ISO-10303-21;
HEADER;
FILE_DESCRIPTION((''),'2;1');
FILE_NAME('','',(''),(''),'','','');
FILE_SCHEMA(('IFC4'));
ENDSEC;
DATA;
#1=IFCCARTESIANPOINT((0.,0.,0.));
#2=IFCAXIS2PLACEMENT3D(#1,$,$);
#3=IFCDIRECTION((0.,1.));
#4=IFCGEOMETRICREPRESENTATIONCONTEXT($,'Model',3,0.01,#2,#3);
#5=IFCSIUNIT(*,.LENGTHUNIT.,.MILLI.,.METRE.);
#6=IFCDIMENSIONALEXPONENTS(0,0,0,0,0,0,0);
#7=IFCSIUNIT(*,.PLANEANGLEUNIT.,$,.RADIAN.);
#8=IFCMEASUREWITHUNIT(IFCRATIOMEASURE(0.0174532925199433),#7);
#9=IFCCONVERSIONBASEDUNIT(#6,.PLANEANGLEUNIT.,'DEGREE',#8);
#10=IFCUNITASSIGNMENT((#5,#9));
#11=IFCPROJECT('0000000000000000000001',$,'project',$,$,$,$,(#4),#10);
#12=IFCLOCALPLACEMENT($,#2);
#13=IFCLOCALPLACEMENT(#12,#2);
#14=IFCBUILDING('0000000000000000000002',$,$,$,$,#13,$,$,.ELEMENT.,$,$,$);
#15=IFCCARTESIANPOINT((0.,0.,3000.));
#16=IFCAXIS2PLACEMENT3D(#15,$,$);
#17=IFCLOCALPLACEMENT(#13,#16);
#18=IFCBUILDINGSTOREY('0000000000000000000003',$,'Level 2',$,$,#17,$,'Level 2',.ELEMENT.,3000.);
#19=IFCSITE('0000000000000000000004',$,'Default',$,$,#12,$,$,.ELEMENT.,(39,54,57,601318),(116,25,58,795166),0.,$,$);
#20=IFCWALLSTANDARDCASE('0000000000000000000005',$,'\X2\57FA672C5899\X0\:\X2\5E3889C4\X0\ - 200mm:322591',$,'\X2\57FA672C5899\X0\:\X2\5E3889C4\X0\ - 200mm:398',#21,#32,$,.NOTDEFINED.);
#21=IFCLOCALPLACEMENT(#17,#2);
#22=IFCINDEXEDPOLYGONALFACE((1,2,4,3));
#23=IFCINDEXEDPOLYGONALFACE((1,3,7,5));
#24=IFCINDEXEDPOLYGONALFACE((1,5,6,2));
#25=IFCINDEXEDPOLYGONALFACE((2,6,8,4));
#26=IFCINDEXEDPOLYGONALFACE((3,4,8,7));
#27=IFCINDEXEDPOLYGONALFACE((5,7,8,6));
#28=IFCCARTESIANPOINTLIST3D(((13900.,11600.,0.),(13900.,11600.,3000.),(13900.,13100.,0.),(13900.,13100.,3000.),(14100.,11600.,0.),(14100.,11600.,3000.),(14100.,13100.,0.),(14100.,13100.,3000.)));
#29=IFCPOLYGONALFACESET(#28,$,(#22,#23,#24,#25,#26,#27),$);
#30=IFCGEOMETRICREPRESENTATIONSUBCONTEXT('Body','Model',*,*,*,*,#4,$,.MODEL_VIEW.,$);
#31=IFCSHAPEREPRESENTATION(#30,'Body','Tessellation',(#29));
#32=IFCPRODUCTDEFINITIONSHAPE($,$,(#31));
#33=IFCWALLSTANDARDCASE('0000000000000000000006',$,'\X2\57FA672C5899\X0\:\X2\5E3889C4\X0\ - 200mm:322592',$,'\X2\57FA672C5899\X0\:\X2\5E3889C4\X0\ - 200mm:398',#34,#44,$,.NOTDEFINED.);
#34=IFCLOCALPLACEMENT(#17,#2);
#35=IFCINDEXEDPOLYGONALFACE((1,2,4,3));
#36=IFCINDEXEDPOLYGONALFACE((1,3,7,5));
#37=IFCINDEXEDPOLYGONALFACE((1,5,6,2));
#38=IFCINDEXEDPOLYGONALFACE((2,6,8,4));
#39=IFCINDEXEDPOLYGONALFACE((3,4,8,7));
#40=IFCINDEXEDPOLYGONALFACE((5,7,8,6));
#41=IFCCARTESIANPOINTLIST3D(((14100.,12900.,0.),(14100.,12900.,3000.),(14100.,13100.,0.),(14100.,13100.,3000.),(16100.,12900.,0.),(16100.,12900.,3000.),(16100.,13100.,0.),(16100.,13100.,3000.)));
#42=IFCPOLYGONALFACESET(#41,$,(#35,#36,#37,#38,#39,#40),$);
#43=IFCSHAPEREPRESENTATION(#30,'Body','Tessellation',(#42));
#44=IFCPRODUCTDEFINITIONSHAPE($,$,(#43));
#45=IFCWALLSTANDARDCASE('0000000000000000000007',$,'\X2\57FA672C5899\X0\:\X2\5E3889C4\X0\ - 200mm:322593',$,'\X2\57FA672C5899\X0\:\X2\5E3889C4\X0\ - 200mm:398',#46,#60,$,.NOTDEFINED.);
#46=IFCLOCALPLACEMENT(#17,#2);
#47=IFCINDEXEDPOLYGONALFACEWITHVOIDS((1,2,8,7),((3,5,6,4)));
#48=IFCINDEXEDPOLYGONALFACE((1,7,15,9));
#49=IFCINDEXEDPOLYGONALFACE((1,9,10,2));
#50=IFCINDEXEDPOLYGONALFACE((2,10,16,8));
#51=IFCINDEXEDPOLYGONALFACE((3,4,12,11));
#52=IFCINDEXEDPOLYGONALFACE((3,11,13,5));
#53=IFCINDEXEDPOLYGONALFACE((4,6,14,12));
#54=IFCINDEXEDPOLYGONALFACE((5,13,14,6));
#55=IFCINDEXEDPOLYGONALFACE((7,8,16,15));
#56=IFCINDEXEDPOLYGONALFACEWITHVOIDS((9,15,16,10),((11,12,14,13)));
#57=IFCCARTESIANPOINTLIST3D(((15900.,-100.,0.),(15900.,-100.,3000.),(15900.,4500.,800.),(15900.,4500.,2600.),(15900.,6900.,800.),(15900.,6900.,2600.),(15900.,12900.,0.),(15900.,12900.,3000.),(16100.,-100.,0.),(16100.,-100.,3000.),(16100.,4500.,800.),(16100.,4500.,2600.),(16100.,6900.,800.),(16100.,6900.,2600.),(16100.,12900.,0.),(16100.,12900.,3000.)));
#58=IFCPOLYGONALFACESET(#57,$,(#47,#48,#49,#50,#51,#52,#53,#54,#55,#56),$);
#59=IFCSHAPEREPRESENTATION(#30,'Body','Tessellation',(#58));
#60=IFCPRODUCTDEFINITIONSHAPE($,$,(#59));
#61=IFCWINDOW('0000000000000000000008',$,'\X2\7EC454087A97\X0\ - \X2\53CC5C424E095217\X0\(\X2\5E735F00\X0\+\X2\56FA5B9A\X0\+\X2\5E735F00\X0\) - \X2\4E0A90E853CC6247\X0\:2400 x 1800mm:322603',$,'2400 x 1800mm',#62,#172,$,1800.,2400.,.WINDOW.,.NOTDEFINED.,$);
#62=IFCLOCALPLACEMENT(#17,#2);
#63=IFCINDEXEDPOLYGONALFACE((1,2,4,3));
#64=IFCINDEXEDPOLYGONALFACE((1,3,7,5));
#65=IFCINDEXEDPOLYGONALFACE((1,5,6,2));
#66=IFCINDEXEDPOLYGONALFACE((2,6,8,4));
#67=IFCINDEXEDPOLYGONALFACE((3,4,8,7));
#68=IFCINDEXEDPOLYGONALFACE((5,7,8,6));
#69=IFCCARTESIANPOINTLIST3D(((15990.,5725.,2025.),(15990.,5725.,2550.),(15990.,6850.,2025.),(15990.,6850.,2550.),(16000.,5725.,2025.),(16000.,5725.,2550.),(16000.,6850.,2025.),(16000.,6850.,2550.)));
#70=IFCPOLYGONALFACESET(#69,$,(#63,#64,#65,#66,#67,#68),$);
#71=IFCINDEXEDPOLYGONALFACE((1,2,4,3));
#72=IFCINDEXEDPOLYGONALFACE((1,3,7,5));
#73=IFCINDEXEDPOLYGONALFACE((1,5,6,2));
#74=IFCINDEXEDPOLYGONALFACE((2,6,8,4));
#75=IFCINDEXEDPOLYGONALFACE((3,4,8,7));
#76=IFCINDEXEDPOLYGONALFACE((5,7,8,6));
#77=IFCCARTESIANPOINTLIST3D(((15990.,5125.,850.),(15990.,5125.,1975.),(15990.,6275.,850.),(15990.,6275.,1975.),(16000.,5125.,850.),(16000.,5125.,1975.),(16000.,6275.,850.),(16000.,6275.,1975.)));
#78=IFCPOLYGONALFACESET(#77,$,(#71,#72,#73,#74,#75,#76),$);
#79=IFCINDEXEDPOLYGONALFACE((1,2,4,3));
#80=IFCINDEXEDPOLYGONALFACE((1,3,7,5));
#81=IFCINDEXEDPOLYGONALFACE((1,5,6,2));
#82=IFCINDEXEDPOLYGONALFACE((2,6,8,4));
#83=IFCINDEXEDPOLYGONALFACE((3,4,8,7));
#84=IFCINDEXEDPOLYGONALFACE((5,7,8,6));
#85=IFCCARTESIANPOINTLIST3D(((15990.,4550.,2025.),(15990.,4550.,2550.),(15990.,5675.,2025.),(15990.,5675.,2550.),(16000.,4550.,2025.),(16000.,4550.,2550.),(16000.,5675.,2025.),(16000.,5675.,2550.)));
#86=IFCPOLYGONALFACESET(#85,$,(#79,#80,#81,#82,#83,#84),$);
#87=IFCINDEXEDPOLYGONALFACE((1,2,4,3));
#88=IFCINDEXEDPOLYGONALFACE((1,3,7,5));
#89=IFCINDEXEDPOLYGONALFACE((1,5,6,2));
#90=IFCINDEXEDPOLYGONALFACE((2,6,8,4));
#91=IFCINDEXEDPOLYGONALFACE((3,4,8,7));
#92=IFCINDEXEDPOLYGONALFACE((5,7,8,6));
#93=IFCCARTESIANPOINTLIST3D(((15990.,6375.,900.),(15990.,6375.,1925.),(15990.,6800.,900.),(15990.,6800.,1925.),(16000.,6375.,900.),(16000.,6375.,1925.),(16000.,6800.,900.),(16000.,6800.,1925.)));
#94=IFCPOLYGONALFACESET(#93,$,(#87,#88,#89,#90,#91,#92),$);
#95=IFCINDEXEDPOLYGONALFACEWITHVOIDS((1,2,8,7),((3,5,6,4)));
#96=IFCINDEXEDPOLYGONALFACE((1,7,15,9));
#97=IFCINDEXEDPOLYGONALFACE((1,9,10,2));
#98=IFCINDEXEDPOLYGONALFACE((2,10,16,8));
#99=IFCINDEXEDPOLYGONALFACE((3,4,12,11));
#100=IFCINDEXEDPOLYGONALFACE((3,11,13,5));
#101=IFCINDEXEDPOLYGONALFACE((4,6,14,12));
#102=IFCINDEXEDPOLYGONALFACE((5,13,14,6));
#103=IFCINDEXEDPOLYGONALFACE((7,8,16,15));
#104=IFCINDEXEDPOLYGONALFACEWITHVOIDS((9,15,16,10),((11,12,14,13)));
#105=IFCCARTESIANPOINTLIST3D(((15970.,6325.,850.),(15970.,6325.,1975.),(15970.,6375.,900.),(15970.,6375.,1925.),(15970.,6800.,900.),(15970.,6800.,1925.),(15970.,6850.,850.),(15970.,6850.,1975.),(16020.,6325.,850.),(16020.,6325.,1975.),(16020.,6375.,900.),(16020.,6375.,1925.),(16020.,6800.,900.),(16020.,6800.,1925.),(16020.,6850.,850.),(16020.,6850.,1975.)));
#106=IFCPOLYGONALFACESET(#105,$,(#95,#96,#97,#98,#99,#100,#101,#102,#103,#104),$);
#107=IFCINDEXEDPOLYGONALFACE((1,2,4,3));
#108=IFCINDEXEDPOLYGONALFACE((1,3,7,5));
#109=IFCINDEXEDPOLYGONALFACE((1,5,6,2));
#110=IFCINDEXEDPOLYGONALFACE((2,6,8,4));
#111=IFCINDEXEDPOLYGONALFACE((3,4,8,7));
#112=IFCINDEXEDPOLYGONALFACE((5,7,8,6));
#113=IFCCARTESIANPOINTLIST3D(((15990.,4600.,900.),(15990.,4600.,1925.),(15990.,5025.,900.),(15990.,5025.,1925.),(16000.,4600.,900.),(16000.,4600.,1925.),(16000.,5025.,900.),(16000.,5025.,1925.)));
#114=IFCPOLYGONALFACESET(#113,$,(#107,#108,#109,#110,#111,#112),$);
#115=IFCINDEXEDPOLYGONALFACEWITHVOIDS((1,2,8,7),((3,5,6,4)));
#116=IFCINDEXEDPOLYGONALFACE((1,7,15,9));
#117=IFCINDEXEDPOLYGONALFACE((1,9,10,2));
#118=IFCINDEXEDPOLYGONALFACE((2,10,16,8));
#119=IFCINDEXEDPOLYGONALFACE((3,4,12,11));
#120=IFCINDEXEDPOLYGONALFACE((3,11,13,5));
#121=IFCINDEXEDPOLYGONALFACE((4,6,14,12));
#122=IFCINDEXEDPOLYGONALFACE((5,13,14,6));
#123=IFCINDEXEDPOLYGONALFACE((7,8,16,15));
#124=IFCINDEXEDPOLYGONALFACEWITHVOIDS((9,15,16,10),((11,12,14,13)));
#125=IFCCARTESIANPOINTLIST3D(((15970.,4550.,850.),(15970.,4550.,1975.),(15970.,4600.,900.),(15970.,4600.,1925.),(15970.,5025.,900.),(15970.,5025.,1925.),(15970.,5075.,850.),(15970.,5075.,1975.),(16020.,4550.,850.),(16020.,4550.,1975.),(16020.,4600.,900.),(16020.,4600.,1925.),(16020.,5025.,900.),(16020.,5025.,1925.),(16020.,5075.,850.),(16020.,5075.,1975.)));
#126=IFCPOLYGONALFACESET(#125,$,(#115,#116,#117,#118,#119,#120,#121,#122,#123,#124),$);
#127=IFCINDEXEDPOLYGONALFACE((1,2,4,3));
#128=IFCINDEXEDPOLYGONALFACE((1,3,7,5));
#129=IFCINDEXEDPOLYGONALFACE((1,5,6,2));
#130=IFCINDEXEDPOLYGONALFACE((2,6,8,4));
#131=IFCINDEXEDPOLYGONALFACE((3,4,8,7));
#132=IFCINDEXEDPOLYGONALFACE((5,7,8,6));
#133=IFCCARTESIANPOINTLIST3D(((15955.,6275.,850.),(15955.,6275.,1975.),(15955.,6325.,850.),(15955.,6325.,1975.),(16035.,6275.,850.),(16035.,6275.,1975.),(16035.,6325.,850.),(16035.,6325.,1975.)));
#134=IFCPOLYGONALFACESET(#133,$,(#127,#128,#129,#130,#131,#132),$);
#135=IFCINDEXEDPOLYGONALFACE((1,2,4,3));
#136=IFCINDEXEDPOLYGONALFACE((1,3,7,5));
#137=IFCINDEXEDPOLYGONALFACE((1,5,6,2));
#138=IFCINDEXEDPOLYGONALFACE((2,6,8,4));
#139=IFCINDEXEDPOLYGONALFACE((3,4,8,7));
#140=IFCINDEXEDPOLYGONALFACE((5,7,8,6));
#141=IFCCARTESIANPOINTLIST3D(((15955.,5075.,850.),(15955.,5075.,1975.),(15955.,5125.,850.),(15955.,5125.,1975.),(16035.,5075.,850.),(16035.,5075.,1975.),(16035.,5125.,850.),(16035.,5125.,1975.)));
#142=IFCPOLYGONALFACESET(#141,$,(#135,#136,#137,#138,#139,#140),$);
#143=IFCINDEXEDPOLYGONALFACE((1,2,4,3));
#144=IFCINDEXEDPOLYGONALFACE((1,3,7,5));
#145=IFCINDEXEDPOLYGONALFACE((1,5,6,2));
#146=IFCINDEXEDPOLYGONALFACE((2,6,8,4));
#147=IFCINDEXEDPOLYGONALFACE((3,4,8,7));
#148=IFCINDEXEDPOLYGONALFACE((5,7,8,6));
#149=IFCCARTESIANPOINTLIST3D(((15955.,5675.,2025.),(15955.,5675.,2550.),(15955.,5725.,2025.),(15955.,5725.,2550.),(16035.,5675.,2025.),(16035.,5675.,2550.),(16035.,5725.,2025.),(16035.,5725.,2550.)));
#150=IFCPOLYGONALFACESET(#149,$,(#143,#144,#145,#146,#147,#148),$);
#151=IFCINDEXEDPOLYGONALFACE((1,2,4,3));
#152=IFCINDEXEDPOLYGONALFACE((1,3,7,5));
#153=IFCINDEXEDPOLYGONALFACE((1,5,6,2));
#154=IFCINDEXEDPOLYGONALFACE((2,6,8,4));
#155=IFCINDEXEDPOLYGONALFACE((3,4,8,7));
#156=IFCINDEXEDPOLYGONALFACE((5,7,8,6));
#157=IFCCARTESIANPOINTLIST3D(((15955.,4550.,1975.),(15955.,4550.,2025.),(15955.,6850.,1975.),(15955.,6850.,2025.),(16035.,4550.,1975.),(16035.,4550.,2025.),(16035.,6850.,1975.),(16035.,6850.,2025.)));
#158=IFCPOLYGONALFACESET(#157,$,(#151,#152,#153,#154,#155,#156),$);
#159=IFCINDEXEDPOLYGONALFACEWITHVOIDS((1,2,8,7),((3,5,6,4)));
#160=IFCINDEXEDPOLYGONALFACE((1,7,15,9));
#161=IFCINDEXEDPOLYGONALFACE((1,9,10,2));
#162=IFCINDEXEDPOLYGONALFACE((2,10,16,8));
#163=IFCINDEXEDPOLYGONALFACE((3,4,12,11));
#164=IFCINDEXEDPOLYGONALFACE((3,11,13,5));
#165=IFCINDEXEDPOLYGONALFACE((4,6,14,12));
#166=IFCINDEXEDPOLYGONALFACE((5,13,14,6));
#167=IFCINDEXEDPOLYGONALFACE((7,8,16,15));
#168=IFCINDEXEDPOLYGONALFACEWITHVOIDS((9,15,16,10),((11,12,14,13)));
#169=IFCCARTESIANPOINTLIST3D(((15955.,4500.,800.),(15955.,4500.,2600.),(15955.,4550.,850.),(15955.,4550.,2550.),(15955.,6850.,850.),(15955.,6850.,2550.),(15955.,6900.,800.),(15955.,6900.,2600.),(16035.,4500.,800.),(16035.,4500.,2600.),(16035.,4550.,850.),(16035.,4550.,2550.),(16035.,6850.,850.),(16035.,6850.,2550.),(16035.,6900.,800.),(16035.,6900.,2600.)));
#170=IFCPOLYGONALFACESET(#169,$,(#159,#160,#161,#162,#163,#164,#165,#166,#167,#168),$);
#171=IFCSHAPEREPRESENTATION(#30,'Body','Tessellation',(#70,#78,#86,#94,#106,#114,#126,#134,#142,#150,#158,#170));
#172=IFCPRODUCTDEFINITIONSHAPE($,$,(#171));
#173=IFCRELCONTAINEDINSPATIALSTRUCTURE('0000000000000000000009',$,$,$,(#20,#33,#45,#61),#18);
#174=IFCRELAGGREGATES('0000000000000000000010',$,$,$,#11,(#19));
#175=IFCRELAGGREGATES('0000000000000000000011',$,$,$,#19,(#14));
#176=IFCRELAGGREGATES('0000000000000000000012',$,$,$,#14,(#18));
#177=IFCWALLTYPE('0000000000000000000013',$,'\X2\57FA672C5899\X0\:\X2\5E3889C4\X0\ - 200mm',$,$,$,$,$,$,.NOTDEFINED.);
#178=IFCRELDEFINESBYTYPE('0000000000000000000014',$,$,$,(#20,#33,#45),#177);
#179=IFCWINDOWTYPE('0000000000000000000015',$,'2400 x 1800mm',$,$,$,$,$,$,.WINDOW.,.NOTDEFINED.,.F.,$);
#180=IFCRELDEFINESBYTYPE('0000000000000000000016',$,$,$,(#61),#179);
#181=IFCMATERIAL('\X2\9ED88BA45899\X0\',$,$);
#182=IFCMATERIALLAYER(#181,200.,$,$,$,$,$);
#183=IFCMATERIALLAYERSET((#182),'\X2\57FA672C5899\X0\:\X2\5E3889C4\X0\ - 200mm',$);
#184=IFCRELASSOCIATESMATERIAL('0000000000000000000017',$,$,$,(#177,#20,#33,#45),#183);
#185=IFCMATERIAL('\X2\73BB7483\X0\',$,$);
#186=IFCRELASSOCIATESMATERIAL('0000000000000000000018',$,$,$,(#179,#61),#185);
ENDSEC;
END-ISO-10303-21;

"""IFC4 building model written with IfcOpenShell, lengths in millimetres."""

from ifc_helpers import new_model, entity, si_unit, converted_unit, direction, frame, frame_2d, origin, origin_2d_with_axis, place, context, subcontext, project, spatial, polyline, rectangle, outline, extrude, source, transform, mapped, material, layer, layer_set, layer_usage, type_object, type_shapes, element, fill, save


model = new_model("IFC4")

# Units and contexts
model_context_1 = context("Model", 3, precision=0.01, world=origin(), true_north=direction((0.0, 1.0)))
body_context_1 = subcontext(model_context_1, "Body", "Model", "MODEL_VIEW")
ifc_project = project(units=[si_unit("LENGTHUNIT", "METRE", prefix="MILLI"), converted_unit("PLANEANGLEUNIT", "DEGREE", entity("IfcRatioMeasure", 0.0174532925199433), si_unit("PLANEANGLEUNIT", "RADIAN"), dimensions=[0, 0, 0, 0, 0, 0, 0])], contexts=[model_context_1])

# Site, building, storey
site_placement = place(None, origin())
site = spatial("IfcSite", under=ifc_project, at=site_placement, Name="Default", CompositionType="ELEMENT", RefLatitude=(39, 54, 57, 601318), RefLongitude=(116, 25, 58, 795166), RefElevation=0.0)
building_placement = place(site_placement, origin())
building = spatial("IfcBuilding", under=site, at=building_placement, CompositionType="ELEMENT")
storey_placement = place(building_placement, frame((0.0, 0.0, 3000.0)))
storey = spatial("IfcBuildingStorey", under=building, at=storey_placement, Name="Level 2", LongName="Level 2", CompositionType="ELEMENT", Elevation=3000.0)

# Shared definitions
ifc_material_1 = material(Name="默认墙")
ifc_layer = layer(ifc_material_1, 200.0)
ifc_layer_set = layer_set([ifc_layer], Name="基本墙:常规 - 200mm")
wall_type = type_object("IfcWallType", Name="基本墙:常规 - 200mm", PredefinedType="NOTDEFINED", material=ifc_layer_set)

# Walls
ifc_layer_usage_1 = layer_usage(ifc_layer_set, "AXIS2", "NEGATIVE", 100.0)
wall_1_placement = place(storey_placement, frame((14000.0, 11600.0, 0.0), z_axis=(0.0, 0.0, 1.0), x_axis=(0.0, 1.0, 0.0)))
element("IfcWallStandardCase", 1, at=wall_1_placement, inside=storey, type_object=wall_type, material=ifc_layer_usage_1, Name="基本墙:常规 - 200mm:322591", ObjectType="基本墙:常规 - 200mm:398", PredefinedType="NOTDEFINED", context=body_context_1, shape_type="SweptSolid", body=[
    extrude(rectangle(XDim=1500.0, YDim=200.0, at=frame_2d((750.0, 0.0), x_axis=(-1.0, 0.0))), origin(), (0.0, 0.0, 1.0), 3000.0),
])
ifc_layer_usage_2 = layer_usage(ifc_layer_set, "AXIS2", "NEGATIVE", 100.0)
wall_2_placement = place(storey_placement, frame((14100.0, 13000.0, 0.0)))
element("IfcWallStandardCase", 2, at=wall_2_placement, inside=storey, type_object=wall_type, material=ifc_layer_usage_2, Name="基本墙:常规 - 200mm:322592", ObjectType="基本墙:常规 - 200mm:398", PredefinedType="NOTDEFINED", context=body_context_1, shape_type="SweptSolid", body=[
    extrude(rectangle(XDim=2000.0, YDim=200.0, at=frame_2d((1000.0, 0.0), x_axis=(-1.0, 0.0))), origin(), (0.0, 0.0, 1.0), 3000.0),
])

# Wall, opening, window
ifc_layer_usage_3 = layer_usage(ifc_layer_set, "AXIS2", "NEGATIVE", 100.0)
wall_3_placement = place(storey_placement, frame((16000.0, 12900.0, 0.0), z_axis=(0.0, 0.0, 1.0), x_axis=(0.0, -1.0, 0.0)))
wall_3 = element("IfcWallStandardCase", 3, at=wall_3_placement, inside=storey, type_object=wall_type, material=ifc_layer_usage_3, Name="基本墙:常规 - 200mm:322593", ObjectType="基本墙:常规 - 200mm:398", PredefinedType="NOTDEFINED", context=body_context_1, shape_type="SweptSolid", body=[
    extrude(rectangle(XDim=13000.0, YDim=200.0, at=frame_2d((6500.0, 0.0), x_axis=(-1.0, 0.0))), origin(), (0.0, 0.0, 1.0), 3000.0),
])
opening_1_placement = place(wall_3_placement, frame((6000.0, -100.0, 800.0)))
opening_1 = element("IfcOpeningElement", 4, at=opening_1_placement, cuts=wall_3, ObjectType="Opening", PredefinedType="OPENING", context=body_context_1, shape_type="SweptSolid", body=[
    extrude(rectangle(XDim=1800.0, YDim=2400.0, at=frame_2d((900.0, 1200.0), x_axis=(1.0, 0.0))), frame((0.0, 0.0, 0.0), z_axis=(0.0, 1.0, 0.0), x_axis=(0.0, 0.0, 1.0)), (0.0, 0.0, 1.0), 200.0),
])
ifc_material_2 = material(Name="玻璃")
window_type_1 = type_object("IfcWindowType", Name="2400 x 1800mm", ParameterTakesPrecedence=False, PartitioningType="NOTDEFINED", PredefinedType="WINDOW", material=ifc_material_2)
shared_shape_1 = source(origin(), body_context_1, "Body", "SweptSolid", [
    extrude(rectangle(XDim=10.0, YDim=1125.0, at=origin_2d_with_axis()), frame((612.5, 95.0, 1225.0), z_axis=(0.0, 0.0, 1.0), x_axis=(0.0, 1.0, 0.0)), (0.0, 0.0, 1.0), 525.0),
    extrude(rectangle(XDim=10.0, YDim=1150.0, at=origin_2d_with_axis()), frame((1200.0, 95.0, 50.0), z_axis=(0.0, 0.0, 1.0), x_axis=(0.0, 1.0, 0.0)), (0.0, 0.0, 1.0), 1125.0),
    extrude(rectangle(XDim=10.0, YDim=1125.0, at=origin_2d_with_axis()), frame((1787.5, 95.0, 1225.0), z_axis=(0.0, 0.0, 1.0), x_axis=(0.0, 1.0, 0.0)), (0.0, 0.0, 1.0), 525.0),
    extrude(rectangle(XDim=10.0, YDim=425.0, at=origin_2d_with_axis()), frame((312.5, 95.0, 100.0), z_axis=(0.0, 0.0, 1.0), x_axis=(0.0, 1.0, 0.0)), (0.0, 0.0, 1.0), 1025.0),
    extrude(outline(polyline([(-562.5, -262.5), (562.5, -262.5), (562.5, 262.5), (-562.5, 262.5), (-562.5, -262.5)]), holes=[polyline([(512.5, -212.5), (-512.5, -212.5), (-512.5, 212.5), (512.5, 212.5), (512.5, -212.5)])]), frame((312.5, 70.0, 612.5), z_axis=(0.0, 1.0, 0.0), x_axis=(0.0, 0.0, -1.0)), (0.0, 0.0, 1.0), 50.0),
    extrude(rectangle(XDim=10.0, YDim=425.0, at=frame_2d((0.0, 0.0), x_axis=(1.0, 0.0))), frame((2087.5, 95.0, 100.0), z_axis=(0.0, 0.0, 1.0), x_axis=(0.0, 1.0, 0.0)), (0.0, 0.0, 1.0), 1025.0),
    extrude(outline(polyline([(-562.5, -262.5), (562.5, -262.5), (562.5, 262.5), (-562.5, 262.5), (-562.5, -262.5)]), holes=[polyline([(512.5, -212.5), (-512.5, -212.5), (-512.5, 212.5), (512.5, 212.5), (512.5, -212.5)])]), frame((2087.5, 70.0, 612.5), z_axis=(0.0, 1.0, 0.0), x_axis=(0.0, 0.0, -1.0)), (0.0, 0.0, 1.0), 50.0),
    extrude(rectangle(XDim=80.0, YDim=50.0, at=origin_2d_with_axis()), frame((600.0, 95.0, 50.0), z_axis=(0.0, 0.0, 1.0), x_axis=(0.0, -1.0, 0.0)), (0.0, 0.0, 1.0), 1125.0),
    extrude(rectangle(XDim=80.0, YDim=50.0, at=origin_2d_with_axis()), frame((1800.0, 95.0, 50.0), z_axis=(0.0, 0.0, 1.0), x_axis=(0.0, -1.0, 0.0)), (0.0, 0.0, 1.0), 1125.0),
    extrude(rectangle(XDim=80.0, YDim=50.0, at=frame_2d((0.0, 0.0), x_axis=(1.0, 0.0))), frame((1200.0, 95.0, 1225.0), z_axis=(0.0, 0.0, 1.0), x_axis=(0.0, -1.0, 0.0)), (0.0, 0.0, 1.0), 525.0),
    extrude(rectangle(XDim=80.0, YDim=2300.0, at=frame_2d((0.0, 0.0), x_axis=(1.0, 0.0))), frame((1200.0, 95.0, 1175.0), z_axis=(0.0, 0.0, 1.0), x_axis=(0.0, -1.0, 0.0)), (0.0, 0.0, 1.0), 50.0),
    extrude(outline(polyline([(-1200.0, -900.0), (1200.0, -900.0), (1200.0, 900.0), (-1200.0, 900.0), (-1200.0, -900.0)]), holes=[polyline([(1150.0, -850.0), (-1150.0, -850.0), (-1150.0, 850.0), (1150.0, 850.0), (1150.0, -850.0)])]), frame((1200.0, 55.0, 900.0), z_axis=(0.0, 1.0, 0.0), x_axis=(1.0, 0.0, 0.0)), (0.0, 0.0, 1.0), 80.0),
])
type_shapes(window_type_1, [shared_shape_1])
window_1_placement = place(opening_1_placement, origin())
window_1 = element("IfcWindow", 5, at=window_1_placement, inside=storey, type_object=window_type_1, material=ifc_material_2, Name="组合窗 - 双层三列(平开+固定+平开) - 上部双扇:2400 x 1800mm:322603", ObjectType="2400 x 1800mm", OverallHeight=1800.0, OverallWidth=2400.0, PartitioningType="NOTDEFINED", PredefinedType="WINDOW", context=body_context_1, shape_type="MappedRepresentation", body=[
    mapped(shared_shape_1, transform((0.0, 0.0, 0.0), scale=1.0)),
])
fill(opening_1, window_1)

save(model, "model.ifc")
